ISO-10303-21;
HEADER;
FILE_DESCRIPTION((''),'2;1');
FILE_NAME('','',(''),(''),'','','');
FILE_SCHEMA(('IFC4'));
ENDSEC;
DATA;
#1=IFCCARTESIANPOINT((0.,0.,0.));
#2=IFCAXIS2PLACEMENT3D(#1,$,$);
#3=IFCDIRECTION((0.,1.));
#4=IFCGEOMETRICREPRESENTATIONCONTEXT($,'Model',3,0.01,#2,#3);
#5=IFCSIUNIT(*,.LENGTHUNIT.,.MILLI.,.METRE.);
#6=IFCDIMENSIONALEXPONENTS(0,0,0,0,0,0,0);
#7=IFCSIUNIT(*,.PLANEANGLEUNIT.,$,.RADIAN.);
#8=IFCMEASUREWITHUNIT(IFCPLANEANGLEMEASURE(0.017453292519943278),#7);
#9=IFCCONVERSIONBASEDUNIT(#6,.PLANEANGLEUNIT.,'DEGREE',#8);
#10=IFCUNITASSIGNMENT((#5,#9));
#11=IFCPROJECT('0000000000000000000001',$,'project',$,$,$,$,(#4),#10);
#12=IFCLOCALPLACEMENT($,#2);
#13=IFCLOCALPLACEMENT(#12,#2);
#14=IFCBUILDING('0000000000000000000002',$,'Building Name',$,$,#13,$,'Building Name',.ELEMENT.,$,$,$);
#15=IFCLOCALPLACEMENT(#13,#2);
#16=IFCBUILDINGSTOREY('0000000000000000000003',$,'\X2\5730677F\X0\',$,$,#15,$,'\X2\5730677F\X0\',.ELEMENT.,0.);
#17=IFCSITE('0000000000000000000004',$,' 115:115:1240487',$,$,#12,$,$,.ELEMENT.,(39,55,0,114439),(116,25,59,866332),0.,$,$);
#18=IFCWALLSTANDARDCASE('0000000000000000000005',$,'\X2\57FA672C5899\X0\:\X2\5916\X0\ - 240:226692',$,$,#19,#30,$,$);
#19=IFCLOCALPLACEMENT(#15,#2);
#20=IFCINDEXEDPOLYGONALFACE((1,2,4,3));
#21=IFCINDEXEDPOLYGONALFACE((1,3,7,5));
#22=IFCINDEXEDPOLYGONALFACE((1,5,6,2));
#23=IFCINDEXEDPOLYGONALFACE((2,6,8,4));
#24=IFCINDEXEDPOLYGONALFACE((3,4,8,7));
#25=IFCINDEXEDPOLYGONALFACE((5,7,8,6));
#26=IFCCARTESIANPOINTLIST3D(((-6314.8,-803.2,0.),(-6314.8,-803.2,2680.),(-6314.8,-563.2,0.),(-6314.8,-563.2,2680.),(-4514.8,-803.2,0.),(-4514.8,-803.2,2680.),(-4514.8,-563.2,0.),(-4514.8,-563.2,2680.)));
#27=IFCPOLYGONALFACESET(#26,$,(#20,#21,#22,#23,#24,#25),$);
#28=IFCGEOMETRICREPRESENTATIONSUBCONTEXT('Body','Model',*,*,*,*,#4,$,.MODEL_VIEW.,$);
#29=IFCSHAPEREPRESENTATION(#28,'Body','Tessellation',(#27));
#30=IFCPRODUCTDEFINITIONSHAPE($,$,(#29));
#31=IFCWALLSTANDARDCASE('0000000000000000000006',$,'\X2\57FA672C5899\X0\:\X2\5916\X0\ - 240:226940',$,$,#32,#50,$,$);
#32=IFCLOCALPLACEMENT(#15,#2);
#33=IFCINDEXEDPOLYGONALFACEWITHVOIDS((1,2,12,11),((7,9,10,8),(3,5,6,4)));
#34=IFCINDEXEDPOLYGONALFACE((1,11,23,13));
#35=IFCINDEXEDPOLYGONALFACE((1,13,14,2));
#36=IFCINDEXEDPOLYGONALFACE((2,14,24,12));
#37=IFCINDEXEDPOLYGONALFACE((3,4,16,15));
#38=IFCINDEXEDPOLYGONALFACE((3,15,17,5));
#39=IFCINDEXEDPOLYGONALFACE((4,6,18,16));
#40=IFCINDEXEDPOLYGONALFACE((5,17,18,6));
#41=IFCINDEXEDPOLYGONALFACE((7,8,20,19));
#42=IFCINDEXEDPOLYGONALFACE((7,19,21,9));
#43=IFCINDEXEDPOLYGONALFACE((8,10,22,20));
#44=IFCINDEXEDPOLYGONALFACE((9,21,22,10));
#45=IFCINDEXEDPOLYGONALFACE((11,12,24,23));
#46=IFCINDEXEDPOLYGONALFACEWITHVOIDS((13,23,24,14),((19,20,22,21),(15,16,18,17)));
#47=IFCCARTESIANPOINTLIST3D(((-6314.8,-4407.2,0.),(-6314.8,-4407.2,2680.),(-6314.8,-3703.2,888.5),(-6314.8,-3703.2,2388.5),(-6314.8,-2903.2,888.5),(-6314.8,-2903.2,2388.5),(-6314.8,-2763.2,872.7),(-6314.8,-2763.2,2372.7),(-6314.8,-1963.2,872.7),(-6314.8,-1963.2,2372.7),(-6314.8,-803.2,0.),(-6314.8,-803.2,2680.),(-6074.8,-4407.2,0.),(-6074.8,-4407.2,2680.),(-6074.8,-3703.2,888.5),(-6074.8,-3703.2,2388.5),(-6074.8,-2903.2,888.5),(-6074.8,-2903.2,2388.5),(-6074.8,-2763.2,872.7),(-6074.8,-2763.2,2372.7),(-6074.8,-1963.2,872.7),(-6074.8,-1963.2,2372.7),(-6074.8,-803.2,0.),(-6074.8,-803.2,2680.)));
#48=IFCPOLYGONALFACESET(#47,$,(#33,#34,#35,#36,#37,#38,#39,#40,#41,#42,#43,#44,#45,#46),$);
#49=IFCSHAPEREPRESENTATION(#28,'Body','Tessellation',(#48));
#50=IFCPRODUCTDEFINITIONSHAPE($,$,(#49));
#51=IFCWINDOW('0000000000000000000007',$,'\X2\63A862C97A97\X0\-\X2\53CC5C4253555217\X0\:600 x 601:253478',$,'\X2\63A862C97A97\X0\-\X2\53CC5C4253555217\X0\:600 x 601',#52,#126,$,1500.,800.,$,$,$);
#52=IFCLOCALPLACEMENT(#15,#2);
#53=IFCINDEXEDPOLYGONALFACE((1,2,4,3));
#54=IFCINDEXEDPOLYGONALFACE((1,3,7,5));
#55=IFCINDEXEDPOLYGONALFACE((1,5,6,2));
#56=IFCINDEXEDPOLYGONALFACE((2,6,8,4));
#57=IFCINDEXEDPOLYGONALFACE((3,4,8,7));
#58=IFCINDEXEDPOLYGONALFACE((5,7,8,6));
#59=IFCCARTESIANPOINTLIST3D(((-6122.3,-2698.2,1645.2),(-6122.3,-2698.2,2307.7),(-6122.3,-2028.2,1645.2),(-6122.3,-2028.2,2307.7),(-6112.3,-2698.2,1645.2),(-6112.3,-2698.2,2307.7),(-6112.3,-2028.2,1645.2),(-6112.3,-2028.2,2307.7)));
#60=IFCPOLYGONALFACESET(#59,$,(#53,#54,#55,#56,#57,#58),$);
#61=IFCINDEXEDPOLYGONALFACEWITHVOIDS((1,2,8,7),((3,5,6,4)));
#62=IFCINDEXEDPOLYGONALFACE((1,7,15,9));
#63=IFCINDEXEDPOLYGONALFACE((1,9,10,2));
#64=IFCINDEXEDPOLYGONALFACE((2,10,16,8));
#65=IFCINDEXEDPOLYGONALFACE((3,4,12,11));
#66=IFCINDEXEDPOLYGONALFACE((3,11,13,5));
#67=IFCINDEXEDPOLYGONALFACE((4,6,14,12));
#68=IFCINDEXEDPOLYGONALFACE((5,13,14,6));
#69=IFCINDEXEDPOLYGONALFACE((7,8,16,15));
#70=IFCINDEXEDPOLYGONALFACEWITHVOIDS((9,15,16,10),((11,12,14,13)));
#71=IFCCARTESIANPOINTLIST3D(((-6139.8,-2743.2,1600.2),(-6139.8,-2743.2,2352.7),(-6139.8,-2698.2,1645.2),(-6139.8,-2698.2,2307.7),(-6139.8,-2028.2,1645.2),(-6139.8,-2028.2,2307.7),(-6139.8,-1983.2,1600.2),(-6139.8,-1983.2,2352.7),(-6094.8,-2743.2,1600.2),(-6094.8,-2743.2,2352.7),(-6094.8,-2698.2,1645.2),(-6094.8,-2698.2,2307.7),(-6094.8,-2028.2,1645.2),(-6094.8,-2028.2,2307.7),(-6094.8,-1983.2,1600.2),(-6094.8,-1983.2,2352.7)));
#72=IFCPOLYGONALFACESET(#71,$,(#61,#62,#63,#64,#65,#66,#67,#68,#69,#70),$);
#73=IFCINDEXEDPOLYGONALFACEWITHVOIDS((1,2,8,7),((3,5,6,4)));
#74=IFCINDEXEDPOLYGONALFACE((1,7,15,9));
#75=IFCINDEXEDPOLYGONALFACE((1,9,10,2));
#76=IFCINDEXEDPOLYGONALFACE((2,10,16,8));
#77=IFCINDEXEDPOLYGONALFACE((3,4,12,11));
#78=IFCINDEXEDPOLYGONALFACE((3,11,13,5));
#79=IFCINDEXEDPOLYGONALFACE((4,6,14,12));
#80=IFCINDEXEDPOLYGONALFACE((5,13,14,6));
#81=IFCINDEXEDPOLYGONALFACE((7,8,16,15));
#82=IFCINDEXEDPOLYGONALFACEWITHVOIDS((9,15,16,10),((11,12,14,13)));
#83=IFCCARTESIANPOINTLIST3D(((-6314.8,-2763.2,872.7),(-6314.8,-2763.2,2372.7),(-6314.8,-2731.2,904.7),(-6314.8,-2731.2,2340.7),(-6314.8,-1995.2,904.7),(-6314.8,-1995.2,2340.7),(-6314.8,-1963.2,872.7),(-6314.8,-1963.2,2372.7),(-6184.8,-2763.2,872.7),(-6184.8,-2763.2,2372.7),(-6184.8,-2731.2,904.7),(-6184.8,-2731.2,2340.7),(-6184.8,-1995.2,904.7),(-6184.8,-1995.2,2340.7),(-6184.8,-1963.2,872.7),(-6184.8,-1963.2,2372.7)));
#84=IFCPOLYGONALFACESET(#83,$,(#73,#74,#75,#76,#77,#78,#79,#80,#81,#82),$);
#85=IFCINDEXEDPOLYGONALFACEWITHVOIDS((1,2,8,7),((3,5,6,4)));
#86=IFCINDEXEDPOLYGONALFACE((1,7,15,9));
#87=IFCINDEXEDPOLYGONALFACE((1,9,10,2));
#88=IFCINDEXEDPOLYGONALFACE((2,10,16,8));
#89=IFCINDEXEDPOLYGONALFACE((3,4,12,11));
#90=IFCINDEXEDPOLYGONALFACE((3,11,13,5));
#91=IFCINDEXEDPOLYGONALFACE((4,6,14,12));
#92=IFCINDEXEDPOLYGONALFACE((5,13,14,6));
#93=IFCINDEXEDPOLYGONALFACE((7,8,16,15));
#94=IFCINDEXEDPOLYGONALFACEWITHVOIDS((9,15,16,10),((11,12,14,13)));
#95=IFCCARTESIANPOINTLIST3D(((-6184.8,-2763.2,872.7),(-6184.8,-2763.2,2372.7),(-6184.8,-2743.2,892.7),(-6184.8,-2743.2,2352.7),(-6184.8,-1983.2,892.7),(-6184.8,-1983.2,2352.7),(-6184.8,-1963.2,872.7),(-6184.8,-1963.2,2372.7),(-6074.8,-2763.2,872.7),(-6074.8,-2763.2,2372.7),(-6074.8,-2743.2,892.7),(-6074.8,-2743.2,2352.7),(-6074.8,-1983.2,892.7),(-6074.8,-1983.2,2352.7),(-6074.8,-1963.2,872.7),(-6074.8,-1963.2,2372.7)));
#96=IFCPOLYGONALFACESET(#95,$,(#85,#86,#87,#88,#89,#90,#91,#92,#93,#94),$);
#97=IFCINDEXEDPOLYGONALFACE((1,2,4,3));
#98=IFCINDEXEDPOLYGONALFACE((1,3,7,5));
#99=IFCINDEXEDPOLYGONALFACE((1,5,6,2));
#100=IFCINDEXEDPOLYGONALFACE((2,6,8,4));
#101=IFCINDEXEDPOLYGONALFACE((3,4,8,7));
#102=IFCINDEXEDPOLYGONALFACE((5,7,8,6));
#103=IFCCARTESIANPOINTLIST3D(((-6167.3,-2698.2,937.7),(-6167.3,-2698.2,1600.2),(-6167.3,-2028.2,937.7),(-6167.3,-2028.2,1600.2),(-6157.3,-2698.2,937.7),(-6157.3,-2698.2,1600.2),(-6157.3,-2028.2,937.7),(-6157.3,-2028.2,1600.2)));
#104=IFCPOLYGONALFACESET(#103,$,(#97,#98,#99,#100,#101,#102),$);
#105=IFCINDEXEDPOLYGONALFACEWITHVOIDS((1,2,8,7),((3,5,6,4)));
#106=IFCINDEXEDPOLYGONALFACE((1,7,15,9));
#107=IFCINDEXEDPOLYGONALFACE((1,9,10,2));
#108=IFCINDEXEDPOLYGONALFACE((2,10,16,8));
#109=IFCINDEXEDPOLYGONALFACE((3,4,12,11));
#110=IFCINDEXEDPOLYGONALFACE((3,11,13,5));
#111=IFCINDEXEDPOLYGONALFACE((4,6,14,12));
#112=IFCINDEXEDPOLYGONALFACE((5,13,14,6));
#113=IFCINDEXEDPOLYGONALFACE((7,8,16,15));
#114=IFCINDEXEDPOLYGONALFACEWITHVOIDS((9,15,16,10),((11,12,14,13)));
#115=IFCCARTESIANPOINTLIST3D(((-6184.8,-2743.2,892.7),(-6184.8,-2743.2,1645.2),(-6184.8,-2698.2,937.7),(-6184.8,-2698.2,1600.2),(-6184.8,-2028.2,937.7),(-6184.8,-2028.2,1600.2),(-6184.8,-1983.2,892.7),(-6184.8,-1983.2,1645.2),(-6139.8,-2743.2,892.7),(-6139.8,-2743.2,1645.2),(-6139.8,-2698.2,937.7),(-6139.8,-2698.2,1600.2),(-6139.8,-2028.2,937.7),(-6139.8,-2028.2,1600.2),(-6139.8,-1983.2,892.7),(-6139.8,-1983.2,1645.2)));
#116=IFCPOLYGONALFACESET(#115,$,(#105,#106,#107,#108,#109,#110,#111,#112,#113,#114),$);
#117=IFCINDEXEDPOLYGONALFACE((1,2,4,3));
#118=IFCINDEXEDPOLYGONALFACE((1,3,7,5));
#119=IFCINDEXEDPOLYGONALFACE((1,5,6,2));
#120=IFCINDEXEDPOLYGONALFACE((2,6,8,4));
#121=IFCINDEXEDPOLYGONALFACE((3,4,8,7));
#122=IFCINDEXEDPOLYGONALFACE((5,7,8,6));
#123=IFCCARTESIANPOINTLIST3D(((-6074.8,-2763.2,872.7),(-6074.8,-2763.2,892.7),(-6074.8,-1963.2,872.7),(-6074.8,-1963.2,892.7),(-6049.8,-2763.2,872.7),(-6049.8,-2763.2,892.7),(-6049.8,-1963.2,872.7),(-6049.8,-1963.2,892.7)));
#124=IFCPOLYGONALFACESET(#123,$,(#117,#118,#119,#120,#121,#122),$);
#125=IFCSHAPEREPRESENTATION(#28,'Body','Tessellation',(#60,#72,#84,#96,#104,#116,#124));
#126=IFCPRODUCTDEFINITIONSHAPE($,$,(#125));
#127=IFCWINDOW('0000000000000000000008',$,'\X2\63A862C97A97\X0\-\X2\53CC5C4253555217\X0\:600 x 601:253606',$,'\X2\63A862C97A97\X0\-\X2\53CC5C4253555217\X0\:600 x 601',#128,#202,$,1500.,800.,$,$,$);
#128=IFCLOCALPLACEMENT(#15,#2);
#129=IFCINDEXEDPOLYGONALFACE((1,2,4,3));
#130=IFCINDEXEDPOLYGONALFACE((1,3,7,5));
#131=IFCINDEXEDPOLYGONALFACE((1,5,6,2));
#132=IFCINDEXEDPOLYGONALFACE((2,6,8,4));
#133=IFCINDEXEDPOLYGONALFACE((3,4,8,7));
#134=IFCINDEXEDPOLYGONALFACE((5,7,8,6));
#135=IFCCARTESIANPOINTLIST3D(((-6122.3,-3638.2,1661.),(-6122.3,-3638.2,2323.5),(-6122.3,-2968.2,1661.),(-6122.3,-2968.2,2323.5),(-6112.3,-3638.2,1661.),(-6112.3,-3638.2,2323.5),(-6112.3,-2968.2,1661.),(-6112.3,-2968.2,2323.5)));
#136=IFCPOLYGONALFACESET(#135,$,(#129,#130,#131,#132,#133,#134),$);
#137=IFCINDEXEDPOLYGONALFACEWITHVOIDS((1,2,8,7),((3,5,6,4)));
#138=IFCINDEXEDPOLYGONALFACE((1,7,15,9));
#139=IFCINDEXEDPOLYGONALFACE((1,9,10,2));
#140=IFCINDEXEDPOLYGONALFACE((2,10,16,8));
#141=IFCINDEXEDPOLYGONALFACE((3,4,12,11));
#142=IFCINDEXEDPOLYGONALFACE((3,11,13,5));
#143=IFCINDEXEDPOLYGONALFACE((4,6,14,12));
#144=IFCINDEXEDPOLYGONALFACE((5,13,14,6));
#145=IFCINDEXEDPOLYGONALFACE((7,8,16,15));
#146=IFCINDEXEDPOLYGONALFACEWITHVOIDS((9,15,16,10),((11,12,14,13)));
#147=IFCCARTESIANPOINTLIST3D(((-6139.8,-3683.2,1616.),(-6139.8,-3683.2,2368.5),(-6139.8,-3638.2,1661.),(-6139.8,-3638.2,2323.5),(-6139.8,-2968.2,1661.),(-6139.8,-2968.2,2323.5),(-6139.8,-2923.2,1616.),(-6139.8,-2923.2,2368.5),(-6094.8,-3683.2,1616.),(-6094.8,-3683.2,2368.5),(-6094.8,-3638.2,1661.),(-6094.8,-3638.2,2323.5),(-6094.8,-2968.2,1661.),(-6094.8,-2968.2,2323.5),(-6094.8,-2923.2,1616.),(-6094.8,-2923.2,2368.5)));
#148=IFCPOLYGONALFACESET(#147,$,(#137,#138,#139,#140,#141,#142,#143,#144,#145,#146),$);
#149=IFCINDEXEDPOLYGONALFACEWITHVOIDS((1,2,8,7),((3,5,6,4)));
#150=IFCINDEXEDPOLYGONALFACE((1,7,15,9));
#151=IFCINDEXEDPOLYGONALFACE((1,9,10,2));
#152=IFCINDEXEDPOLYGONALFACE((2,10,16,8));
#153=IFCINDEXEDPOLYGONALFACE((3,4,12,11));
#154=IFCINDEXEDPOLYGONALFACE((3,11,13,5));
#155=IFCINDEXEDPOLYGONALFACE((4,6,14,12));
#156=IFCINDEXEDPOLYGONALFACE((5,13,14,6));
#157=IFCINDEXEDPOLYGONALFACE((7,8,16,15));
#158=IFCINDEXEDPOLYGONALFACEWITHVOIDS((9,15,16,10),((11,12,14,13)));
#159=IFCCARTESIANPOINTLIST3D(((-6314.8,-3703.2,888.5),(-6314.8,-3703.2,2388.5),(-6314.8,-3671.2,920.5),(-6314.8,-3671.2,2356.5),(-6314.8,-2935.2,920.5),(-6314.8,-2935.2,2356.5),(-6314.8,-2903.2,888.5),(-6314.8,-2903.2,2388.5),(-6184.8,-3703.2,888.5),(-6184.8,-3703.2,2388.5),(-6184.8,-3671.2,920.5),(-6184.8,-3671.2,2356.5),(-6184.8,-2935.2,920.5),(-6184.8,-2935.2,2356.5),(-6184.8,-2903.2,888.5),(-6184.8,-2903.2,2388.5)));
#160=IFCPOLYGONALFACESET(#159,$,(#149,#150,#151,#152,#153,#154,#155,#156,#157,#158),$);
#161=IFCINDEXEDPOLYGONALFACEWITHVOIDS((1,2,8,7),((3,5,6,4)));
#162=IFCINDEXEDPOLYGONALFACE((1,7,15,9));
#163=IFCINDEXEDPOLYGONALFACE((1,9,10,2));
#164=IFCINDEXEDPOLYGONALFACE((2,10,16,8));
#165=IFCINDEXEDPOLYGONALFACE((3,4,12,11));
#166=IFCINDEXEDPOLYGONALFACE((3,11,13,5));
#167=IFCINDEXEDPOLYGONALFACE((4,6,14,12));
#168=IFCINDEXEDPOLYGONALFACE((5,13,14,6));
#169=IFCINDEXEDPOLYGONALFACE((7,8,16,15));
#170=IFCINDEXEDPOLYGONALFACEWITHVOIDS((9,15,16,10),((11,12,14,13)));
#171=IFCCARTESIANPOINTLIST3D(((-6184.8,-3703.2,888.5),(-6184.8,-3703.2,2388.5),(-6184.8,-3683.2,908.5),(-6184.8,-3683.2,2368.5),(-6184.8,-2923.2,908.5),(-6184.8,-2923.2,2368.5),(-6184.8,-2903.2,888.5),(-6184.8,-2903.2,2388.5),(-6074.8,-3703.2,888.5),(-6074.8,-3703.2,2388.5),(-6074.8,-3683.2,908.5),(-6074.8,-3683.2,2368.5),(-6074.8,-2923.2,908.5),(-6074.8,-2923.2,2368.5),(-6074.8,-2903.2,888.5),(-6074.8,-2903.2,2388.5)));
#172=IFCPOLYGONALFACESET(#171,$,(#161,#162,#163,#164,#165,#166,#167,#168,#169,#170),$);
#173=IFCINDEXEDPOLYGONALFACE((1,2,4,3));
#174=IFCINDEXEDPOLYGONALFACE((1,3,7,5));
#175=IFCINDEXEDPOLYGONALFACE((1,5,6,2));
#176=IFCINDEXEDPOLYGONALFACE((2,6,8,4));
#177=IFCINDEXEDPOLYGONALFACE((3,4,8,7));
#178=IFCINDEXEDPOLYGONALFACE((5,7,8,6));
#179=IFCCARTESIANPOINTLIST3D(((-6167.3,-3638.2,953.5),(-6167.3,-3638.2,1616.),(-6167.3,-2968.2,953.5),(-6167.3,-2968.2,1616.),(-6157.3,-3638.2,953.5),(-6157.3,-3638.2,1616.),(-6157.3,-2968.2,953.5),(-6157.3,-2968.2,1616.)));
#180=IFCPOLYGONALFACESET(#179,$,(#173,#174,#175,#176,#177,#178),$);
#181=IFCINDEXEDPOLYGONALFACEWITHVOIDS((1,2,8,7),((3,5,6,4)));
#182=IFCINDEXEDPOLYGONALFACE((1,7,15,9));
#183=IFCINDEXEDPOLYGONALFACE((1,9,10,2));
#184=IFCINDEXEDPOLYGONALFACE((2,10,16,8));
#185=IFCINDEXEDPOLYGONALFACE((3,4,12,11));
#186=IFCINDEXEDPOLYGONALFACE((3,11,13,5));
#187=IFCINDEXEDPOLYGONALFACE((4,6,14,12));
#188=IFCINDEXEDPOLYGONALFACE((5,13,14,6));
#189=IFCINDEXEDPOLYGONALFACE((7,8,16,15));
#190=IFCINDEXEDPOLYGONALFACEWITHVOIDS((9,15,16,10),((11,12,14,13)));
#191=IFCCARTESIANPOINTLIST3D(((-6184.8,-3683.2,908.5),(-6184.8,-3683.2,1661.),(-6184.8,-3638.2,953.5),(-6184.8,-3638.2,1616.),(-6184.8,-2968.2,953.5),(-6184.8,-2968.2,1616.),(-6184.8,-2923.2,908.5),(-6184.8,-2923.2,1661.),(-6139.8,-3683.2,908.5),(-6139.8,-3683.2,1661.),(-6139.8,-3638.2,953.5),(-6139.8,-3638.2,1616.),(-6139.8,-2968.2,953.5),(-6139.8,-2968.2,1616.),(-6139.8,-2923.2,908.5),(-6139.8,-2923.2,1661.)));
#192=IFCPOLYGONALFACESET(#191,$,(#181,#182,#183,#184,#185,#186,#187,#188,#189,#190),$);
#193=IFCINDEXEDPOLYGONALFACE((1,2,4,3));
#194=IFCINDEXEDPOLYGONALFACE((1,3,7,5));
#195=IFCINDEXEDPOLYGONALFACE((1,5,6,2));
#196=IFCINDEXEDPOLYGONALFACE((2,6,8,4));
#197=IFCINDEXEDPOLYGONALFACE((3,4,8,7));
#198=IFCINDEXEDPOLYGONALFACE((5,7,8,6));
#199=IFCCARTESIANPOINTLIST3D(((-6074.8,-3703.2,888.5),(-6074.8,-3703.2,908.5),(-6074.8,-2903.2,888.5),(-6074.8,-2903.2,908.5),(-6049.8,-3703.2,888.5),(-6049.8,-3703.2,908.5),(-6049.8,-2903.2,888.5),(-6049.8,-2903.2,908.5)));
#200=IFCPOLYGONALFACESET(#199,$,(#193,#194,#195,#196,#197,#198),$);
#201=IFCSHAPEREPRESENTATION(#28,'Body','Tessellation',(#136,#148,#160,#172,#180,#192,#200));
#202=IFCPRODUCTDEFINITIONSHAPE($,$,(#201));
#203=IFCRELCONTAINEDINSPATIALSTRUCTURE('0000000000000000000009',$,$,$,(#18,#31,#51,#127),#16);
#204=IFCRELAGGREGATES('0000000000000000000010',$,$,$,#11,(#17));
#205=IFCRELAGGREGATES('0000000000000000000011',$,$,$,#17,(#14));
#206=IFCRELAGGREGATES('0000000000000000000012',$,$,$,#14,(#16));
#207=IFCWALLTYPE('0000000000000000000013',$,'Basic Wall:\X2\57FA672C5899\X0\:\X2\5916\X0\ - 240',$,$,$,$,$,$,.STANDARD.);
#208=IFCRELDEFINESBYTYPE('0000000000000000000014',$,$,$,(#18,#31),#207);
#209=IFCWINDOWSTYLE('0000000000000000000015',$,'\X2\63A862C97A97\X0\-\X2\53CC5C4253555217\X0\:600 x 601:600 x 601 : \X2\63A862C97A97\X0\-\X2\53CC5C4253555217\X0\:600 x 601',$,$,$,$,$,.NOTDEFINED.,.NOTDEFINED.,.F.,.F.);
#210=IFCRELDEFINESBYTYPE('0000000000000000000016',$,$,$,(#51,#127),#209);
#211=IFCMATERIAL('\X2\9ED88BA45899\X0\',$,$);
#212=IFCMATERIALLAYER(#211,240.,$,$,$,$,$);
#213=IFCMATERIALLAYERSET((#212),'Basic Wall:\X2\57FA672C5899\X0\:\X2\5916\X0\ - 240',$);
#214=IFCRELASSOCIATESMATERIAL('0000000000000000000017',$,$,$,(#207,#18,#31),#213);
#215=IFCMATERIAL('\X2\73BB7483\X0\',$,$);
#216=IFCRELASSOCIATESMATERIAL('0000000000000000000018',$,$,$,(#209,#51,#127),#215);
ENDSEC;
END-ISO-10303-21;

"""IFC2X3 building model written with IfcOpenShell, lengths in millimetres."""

from ifc_helpers import new_model, entity, si_unit, converted_unit, direction, frame, frame_2d, origin, origin_2d_with_axis, place, context, subcontext, project, spatial, polyline, rectangle, outline, extrude, source, transform, mapped, material, layer, layer_set, layer_usage, type_object, type_shapes, element, fill, save


model = new_model("IFC2X3")

# Units and contexts
model_context = context("Model", 3, precision=0.01, world=origin(), true_north=direction((0.0, 1.0)))
body_context = subcontext(model_context, "Body", "Model", "MODEL_VIEW")
ifc_project = project(units=[si_unit("LENGTHUNIT", "METRE", prefix="MILLI"), converted_unit("PLANEANGLEUNIT", "DEGREE", entity("IfcPlaneAngleMeasure", 0.017453292519943278), si_unit("PLANEANGLEUNIT", "RADIAN"), dimensions=[0, 0, 0, 0, 0, 0, 0])], contexts=[model_context])

# Site, building, storey
site_placement = place(None, origin())
site = spatial("IfcSite", under=ifc_project, at=site_placement, Name=" 115:115:1240487", CompositionType="ELEMENT", RefLatitude=(39, 55, 0, 114439), RefLongitude=(116, 25, 59, 866332), RefElevation=0.0)
building_placement = place(site_placement, origin())
building = spatial("IfcBuilding", under=site, at=building_placement, Name="Building Name", LongName="Building Name", CompositionType="ELEMENT")
storey_placement = place(building_placement, origin())
storey = spatial("IfcBuildingStorey", under=building, at=storey_placement, Name="地板", LongName="地板", CompositionType="ELEMENT", Elevation=0.0)

# Wall
ifc_material_1 = material(Name="默认墙")
ifc_layer_1 = layer(ifc_material_1, 240.0)
ifc_layer_set_1 = layer_set([ifc_layer_1], Name="Basic Wall:基本墙:外 - 240")
ifc_layer_usage_1 = layer_usage(ifc_layer_set_1, "AXIS2", "NEGATIVE", 120.0)
wall_type_1 = type_object("IfcWallType", Name="Basic Wall:基本墙:外 - 240", PredefinedType="STANDARD", material=ifc_layer_set_1)
wall_1_placement = place(storey_placement, frame((-4514.8, -683.2, 0.0), z_axis=(0.0, 0.0, 1.0), x_axis=(-1.0, 0.0, 0.0)))
element("IfcWallStandardCase", 1, at=wall_1_placement, inside=storey, type_object=wall_type_1, material=ifc_layer_usage_1, Name="基本墙:外 - 240:226692", context=body_context, shape_type="SweptSolid", body=[
    extrude(rectangle(XDim=1800.0, YDim=240.0, at=frame_2d((900.0, 0.0), x_axis=(-1.0, 0.0))), origin(), (0.0, 0.0, 1.0), 2680.0),
])

# Wall, openings, windows
ifc_layer_usage_2 = layer_usage(ifc_layer_set_1, "AXIS2", "NEGATIVE", 120.0)
wall_2_placement = place(storey_placement, frame((-6194.8, -803.2, 0.0), z_axis=(0.0, 0.0, 1.0), x_axis=(0.0, -1.0, 0.0)))
wall_2 = element("IfcWallStandardCase", 2, at=wall_2_placement, inside=storey, type_object=wall_type_1, material=ifc_layer_usage_2, Name="基本墙:外 - 240:226940", context=body_context, shape_type="SweptSolid", body=[
    extrude(rectangle(XDim=3604.0, YDim=240.0, at=frame_2d((1802.0, 0.0), x_axis=(-1.0, 0.0))), origin(), (0.0, 0.0, 1.0), 2680.0),
])
opening_1_placement = place(wall_2_placement, frame((-803.2, 6194.8, 0.0), z_axis=(0.0, 0.0, 1.0), x_axis=(0.0, 1.0, 0.0)))
opening_1 = element("IfcOpeningElement", 3, at=opening_1_placement, cuts=wall_2, ObjectType="Opening", context=body_context, shape_type="SweptSolid", body=[
    extrude(rectangle(XDim=1500.0, YDim=800.0, at=frame_2d((0.0, 0.0), x_axis=(0.0, 1.0))), frame((-6317.2, -2363.2, 1622.7), z_axis=(1.0, 0.0, 0.0), x_axis=(0.0, 1.0, 0.0)), (0.0, 0.0, 1.0), 244.8),
])
opening_2_placement = place(wall_2_placement, frame((-803.2, 6194.8, 0.0), z_axis=(0.0, 0.0, 1.0), x_axis=(0.0, 1.0, 0.0)))
opening_2 = element("IfcOpeningElement", 4, at=opening_2_placement, cuts=wall_2, ObjectType="Opening", context=body_context, shape_type="SweptSolid", body=[
    extrude(rectangle(XDim=1500.0, YDim=800.0, at=frame_2d((0.0, 0.0), x_axis=(0.0, 1.0))), frame((-6317.2, -3303.2, 1638.5), z_axis=(1.0, 0.0, 0.0), x_axis=(0.0, 1.0, 0.0)), (0.0, 0.0, 1.0), 244.8),
])
ifc_material_2 = material(Name="玻璃")
window_style_1 = type_object("IfcWindowStyle", Name="推拉窗-双层单列:600 x 601:600 x 601 : 推拉窗-双层单列:600 x 601", ConstructionType="NOTDEFINED", OperationType="NOTDEFINED", ParameterTakesPrecedence=False, Sizeable=False, material=ifc_material_2)
shared_shape_1 = source(origin(), body_context, "Body", "SweptSolid", [
    extrude(rectangle(XDim=670.0, YDim=10.0, at=origin_2d_with_axis()), frame((400.0, -44.9, 772.5)), (0.0, 0.0, 1.0), 662.5),
    extrude(outline(polyline([(-376.2, -380.0), (376.2, -380.0), (376.2, 380.0), (-376.2, 380.0), (-376.2, -380.0)]), holes=[polyline([(331.2, 335.0), (331.2, -335.0), (-331.2, -335.0), (-331.2, 335.0), (331.2, 335.0)])]), frame((400.0, -67.4, 1103.8), z_axis=(0.0, 1.0, 0.0), x_axis=(0.0, 0.0, -1.0)), (0.0, 0.0, 1.0), 45.0),
    extrude(outline(polyline([(-750.0, -400.0), (750.0, -400.0), (750.0, 400.0), (-750.0, 400.0), (-750.0, -400.0)]), holes=[polyline([(718.0, 368.0), (718.0, -368.0), (-718.0, -368.0), (-718.0, 368.0), (718.0, 368.0)])]), frame((400.0, -242.4, 750.0), z_axis=(0.0, 1.0, 0.0), x_axis=(0.0, 0.0, -1.0)), (0.0, 0.0, 1.0), 130.0),
    extrude(outline(polyline([(-400.0, -750.0), (400.0, -750.0), (400.0, 750.0), (-400.0, 750.0), (-400.0, -750.0)]), holes=[polyline([(380.0, 730.0), (380.0, -730.0), (-380.0, -730.0), (-380.0, 730.0), (380.0, 730.0)])]), frame((400.0, -112.4, 750.0), z_axis=(0.0, 1.0, 0.0), x_axis=(-1.0, 0.0, 0.0)), (0.0, 0.0, 1.0), 110.0),
    extrude(rectangle(XDim=670.0, YDim=10.0, at=origin_2d_with_axis()), frame((400.0, -89.9, 65.0)), (0.0, 0.0, 1.0), 662.5),
    extrude(outline(polyline([(-376.2, -380.0), (376.2, -380.0), (376.2, 380.0), (-376.2, 380.0), (-376.2, -380.0)]), holes=[polyline([(331.2, 335.0), (331.2, -335.0), (-331.2, -335.0), (-331.2, 335.0), (331.2, 335.0)])]), frame((400.0, -112.4, 396.3), z_axis=(0.0, 1.0, 0.0), x_axis=(0.0, 0.0, -1.0)), (0.0, 0.0, 1.0), 45.0),
    extrude(rectangle(XDim=800.0, YDim=25.0, at=origin_2d_with_axis()), frame((400.0, 10.1, 0.0)), (0.0, 0.0, 1.0), 20.0),
])
type_shapes(window_style_1, [shared_shape_1])
window_1_placement = place(opening_1_placement, frame((-6072.4, -1963.2, 872.7), z_axis=(0.0, 0.0, 1.0), x_axis=(0.0, -1.0, 0.0)))
window_1 = element("IfcWindow", 5, at=window_1_placement, inside=storey, type_object=window_style_1, material=ifc_material_2, Name="推拉窗-双层单列:600 x 601:253478", ObjectType="推拉窗-双层单列:600 x 601", OverallHeight=1500.0, OverallWidth=800.0, context=body_context, shape_type="MappedRepresentation", body=[
    mapped(shared_shape_1, transform((0.0, 0.0, 0.0), scale=1.0)),
])
fill(opening_1, window_1)
window_2_placement = place(opening_2_placement, frame((-6072.4, -2903.2, 888.5), z_axis=(0.0, 0.0, 1.0), x_axis=(0.0, -1.0, 0.0)))
window_2 = element("IfcWindow", 6, at=window_2_placement, inside=storey, type_object=window_style_1, material=ifc_material_2, Name="推拉窗-双层单列:600 x 601:253606", ObjectType="推拉窗-双层单列:600 x 601", OverallHeight=1500.0, OverallWidth=800.0, context=body_context, shape_type="MappedRepresentation", body=[
    mapped(shared_shape_1, transform((0.0, 0.0, 0.0), scale=1.0)),
])
fill(opening_2, window_2)

save(model, "model.ifc")
